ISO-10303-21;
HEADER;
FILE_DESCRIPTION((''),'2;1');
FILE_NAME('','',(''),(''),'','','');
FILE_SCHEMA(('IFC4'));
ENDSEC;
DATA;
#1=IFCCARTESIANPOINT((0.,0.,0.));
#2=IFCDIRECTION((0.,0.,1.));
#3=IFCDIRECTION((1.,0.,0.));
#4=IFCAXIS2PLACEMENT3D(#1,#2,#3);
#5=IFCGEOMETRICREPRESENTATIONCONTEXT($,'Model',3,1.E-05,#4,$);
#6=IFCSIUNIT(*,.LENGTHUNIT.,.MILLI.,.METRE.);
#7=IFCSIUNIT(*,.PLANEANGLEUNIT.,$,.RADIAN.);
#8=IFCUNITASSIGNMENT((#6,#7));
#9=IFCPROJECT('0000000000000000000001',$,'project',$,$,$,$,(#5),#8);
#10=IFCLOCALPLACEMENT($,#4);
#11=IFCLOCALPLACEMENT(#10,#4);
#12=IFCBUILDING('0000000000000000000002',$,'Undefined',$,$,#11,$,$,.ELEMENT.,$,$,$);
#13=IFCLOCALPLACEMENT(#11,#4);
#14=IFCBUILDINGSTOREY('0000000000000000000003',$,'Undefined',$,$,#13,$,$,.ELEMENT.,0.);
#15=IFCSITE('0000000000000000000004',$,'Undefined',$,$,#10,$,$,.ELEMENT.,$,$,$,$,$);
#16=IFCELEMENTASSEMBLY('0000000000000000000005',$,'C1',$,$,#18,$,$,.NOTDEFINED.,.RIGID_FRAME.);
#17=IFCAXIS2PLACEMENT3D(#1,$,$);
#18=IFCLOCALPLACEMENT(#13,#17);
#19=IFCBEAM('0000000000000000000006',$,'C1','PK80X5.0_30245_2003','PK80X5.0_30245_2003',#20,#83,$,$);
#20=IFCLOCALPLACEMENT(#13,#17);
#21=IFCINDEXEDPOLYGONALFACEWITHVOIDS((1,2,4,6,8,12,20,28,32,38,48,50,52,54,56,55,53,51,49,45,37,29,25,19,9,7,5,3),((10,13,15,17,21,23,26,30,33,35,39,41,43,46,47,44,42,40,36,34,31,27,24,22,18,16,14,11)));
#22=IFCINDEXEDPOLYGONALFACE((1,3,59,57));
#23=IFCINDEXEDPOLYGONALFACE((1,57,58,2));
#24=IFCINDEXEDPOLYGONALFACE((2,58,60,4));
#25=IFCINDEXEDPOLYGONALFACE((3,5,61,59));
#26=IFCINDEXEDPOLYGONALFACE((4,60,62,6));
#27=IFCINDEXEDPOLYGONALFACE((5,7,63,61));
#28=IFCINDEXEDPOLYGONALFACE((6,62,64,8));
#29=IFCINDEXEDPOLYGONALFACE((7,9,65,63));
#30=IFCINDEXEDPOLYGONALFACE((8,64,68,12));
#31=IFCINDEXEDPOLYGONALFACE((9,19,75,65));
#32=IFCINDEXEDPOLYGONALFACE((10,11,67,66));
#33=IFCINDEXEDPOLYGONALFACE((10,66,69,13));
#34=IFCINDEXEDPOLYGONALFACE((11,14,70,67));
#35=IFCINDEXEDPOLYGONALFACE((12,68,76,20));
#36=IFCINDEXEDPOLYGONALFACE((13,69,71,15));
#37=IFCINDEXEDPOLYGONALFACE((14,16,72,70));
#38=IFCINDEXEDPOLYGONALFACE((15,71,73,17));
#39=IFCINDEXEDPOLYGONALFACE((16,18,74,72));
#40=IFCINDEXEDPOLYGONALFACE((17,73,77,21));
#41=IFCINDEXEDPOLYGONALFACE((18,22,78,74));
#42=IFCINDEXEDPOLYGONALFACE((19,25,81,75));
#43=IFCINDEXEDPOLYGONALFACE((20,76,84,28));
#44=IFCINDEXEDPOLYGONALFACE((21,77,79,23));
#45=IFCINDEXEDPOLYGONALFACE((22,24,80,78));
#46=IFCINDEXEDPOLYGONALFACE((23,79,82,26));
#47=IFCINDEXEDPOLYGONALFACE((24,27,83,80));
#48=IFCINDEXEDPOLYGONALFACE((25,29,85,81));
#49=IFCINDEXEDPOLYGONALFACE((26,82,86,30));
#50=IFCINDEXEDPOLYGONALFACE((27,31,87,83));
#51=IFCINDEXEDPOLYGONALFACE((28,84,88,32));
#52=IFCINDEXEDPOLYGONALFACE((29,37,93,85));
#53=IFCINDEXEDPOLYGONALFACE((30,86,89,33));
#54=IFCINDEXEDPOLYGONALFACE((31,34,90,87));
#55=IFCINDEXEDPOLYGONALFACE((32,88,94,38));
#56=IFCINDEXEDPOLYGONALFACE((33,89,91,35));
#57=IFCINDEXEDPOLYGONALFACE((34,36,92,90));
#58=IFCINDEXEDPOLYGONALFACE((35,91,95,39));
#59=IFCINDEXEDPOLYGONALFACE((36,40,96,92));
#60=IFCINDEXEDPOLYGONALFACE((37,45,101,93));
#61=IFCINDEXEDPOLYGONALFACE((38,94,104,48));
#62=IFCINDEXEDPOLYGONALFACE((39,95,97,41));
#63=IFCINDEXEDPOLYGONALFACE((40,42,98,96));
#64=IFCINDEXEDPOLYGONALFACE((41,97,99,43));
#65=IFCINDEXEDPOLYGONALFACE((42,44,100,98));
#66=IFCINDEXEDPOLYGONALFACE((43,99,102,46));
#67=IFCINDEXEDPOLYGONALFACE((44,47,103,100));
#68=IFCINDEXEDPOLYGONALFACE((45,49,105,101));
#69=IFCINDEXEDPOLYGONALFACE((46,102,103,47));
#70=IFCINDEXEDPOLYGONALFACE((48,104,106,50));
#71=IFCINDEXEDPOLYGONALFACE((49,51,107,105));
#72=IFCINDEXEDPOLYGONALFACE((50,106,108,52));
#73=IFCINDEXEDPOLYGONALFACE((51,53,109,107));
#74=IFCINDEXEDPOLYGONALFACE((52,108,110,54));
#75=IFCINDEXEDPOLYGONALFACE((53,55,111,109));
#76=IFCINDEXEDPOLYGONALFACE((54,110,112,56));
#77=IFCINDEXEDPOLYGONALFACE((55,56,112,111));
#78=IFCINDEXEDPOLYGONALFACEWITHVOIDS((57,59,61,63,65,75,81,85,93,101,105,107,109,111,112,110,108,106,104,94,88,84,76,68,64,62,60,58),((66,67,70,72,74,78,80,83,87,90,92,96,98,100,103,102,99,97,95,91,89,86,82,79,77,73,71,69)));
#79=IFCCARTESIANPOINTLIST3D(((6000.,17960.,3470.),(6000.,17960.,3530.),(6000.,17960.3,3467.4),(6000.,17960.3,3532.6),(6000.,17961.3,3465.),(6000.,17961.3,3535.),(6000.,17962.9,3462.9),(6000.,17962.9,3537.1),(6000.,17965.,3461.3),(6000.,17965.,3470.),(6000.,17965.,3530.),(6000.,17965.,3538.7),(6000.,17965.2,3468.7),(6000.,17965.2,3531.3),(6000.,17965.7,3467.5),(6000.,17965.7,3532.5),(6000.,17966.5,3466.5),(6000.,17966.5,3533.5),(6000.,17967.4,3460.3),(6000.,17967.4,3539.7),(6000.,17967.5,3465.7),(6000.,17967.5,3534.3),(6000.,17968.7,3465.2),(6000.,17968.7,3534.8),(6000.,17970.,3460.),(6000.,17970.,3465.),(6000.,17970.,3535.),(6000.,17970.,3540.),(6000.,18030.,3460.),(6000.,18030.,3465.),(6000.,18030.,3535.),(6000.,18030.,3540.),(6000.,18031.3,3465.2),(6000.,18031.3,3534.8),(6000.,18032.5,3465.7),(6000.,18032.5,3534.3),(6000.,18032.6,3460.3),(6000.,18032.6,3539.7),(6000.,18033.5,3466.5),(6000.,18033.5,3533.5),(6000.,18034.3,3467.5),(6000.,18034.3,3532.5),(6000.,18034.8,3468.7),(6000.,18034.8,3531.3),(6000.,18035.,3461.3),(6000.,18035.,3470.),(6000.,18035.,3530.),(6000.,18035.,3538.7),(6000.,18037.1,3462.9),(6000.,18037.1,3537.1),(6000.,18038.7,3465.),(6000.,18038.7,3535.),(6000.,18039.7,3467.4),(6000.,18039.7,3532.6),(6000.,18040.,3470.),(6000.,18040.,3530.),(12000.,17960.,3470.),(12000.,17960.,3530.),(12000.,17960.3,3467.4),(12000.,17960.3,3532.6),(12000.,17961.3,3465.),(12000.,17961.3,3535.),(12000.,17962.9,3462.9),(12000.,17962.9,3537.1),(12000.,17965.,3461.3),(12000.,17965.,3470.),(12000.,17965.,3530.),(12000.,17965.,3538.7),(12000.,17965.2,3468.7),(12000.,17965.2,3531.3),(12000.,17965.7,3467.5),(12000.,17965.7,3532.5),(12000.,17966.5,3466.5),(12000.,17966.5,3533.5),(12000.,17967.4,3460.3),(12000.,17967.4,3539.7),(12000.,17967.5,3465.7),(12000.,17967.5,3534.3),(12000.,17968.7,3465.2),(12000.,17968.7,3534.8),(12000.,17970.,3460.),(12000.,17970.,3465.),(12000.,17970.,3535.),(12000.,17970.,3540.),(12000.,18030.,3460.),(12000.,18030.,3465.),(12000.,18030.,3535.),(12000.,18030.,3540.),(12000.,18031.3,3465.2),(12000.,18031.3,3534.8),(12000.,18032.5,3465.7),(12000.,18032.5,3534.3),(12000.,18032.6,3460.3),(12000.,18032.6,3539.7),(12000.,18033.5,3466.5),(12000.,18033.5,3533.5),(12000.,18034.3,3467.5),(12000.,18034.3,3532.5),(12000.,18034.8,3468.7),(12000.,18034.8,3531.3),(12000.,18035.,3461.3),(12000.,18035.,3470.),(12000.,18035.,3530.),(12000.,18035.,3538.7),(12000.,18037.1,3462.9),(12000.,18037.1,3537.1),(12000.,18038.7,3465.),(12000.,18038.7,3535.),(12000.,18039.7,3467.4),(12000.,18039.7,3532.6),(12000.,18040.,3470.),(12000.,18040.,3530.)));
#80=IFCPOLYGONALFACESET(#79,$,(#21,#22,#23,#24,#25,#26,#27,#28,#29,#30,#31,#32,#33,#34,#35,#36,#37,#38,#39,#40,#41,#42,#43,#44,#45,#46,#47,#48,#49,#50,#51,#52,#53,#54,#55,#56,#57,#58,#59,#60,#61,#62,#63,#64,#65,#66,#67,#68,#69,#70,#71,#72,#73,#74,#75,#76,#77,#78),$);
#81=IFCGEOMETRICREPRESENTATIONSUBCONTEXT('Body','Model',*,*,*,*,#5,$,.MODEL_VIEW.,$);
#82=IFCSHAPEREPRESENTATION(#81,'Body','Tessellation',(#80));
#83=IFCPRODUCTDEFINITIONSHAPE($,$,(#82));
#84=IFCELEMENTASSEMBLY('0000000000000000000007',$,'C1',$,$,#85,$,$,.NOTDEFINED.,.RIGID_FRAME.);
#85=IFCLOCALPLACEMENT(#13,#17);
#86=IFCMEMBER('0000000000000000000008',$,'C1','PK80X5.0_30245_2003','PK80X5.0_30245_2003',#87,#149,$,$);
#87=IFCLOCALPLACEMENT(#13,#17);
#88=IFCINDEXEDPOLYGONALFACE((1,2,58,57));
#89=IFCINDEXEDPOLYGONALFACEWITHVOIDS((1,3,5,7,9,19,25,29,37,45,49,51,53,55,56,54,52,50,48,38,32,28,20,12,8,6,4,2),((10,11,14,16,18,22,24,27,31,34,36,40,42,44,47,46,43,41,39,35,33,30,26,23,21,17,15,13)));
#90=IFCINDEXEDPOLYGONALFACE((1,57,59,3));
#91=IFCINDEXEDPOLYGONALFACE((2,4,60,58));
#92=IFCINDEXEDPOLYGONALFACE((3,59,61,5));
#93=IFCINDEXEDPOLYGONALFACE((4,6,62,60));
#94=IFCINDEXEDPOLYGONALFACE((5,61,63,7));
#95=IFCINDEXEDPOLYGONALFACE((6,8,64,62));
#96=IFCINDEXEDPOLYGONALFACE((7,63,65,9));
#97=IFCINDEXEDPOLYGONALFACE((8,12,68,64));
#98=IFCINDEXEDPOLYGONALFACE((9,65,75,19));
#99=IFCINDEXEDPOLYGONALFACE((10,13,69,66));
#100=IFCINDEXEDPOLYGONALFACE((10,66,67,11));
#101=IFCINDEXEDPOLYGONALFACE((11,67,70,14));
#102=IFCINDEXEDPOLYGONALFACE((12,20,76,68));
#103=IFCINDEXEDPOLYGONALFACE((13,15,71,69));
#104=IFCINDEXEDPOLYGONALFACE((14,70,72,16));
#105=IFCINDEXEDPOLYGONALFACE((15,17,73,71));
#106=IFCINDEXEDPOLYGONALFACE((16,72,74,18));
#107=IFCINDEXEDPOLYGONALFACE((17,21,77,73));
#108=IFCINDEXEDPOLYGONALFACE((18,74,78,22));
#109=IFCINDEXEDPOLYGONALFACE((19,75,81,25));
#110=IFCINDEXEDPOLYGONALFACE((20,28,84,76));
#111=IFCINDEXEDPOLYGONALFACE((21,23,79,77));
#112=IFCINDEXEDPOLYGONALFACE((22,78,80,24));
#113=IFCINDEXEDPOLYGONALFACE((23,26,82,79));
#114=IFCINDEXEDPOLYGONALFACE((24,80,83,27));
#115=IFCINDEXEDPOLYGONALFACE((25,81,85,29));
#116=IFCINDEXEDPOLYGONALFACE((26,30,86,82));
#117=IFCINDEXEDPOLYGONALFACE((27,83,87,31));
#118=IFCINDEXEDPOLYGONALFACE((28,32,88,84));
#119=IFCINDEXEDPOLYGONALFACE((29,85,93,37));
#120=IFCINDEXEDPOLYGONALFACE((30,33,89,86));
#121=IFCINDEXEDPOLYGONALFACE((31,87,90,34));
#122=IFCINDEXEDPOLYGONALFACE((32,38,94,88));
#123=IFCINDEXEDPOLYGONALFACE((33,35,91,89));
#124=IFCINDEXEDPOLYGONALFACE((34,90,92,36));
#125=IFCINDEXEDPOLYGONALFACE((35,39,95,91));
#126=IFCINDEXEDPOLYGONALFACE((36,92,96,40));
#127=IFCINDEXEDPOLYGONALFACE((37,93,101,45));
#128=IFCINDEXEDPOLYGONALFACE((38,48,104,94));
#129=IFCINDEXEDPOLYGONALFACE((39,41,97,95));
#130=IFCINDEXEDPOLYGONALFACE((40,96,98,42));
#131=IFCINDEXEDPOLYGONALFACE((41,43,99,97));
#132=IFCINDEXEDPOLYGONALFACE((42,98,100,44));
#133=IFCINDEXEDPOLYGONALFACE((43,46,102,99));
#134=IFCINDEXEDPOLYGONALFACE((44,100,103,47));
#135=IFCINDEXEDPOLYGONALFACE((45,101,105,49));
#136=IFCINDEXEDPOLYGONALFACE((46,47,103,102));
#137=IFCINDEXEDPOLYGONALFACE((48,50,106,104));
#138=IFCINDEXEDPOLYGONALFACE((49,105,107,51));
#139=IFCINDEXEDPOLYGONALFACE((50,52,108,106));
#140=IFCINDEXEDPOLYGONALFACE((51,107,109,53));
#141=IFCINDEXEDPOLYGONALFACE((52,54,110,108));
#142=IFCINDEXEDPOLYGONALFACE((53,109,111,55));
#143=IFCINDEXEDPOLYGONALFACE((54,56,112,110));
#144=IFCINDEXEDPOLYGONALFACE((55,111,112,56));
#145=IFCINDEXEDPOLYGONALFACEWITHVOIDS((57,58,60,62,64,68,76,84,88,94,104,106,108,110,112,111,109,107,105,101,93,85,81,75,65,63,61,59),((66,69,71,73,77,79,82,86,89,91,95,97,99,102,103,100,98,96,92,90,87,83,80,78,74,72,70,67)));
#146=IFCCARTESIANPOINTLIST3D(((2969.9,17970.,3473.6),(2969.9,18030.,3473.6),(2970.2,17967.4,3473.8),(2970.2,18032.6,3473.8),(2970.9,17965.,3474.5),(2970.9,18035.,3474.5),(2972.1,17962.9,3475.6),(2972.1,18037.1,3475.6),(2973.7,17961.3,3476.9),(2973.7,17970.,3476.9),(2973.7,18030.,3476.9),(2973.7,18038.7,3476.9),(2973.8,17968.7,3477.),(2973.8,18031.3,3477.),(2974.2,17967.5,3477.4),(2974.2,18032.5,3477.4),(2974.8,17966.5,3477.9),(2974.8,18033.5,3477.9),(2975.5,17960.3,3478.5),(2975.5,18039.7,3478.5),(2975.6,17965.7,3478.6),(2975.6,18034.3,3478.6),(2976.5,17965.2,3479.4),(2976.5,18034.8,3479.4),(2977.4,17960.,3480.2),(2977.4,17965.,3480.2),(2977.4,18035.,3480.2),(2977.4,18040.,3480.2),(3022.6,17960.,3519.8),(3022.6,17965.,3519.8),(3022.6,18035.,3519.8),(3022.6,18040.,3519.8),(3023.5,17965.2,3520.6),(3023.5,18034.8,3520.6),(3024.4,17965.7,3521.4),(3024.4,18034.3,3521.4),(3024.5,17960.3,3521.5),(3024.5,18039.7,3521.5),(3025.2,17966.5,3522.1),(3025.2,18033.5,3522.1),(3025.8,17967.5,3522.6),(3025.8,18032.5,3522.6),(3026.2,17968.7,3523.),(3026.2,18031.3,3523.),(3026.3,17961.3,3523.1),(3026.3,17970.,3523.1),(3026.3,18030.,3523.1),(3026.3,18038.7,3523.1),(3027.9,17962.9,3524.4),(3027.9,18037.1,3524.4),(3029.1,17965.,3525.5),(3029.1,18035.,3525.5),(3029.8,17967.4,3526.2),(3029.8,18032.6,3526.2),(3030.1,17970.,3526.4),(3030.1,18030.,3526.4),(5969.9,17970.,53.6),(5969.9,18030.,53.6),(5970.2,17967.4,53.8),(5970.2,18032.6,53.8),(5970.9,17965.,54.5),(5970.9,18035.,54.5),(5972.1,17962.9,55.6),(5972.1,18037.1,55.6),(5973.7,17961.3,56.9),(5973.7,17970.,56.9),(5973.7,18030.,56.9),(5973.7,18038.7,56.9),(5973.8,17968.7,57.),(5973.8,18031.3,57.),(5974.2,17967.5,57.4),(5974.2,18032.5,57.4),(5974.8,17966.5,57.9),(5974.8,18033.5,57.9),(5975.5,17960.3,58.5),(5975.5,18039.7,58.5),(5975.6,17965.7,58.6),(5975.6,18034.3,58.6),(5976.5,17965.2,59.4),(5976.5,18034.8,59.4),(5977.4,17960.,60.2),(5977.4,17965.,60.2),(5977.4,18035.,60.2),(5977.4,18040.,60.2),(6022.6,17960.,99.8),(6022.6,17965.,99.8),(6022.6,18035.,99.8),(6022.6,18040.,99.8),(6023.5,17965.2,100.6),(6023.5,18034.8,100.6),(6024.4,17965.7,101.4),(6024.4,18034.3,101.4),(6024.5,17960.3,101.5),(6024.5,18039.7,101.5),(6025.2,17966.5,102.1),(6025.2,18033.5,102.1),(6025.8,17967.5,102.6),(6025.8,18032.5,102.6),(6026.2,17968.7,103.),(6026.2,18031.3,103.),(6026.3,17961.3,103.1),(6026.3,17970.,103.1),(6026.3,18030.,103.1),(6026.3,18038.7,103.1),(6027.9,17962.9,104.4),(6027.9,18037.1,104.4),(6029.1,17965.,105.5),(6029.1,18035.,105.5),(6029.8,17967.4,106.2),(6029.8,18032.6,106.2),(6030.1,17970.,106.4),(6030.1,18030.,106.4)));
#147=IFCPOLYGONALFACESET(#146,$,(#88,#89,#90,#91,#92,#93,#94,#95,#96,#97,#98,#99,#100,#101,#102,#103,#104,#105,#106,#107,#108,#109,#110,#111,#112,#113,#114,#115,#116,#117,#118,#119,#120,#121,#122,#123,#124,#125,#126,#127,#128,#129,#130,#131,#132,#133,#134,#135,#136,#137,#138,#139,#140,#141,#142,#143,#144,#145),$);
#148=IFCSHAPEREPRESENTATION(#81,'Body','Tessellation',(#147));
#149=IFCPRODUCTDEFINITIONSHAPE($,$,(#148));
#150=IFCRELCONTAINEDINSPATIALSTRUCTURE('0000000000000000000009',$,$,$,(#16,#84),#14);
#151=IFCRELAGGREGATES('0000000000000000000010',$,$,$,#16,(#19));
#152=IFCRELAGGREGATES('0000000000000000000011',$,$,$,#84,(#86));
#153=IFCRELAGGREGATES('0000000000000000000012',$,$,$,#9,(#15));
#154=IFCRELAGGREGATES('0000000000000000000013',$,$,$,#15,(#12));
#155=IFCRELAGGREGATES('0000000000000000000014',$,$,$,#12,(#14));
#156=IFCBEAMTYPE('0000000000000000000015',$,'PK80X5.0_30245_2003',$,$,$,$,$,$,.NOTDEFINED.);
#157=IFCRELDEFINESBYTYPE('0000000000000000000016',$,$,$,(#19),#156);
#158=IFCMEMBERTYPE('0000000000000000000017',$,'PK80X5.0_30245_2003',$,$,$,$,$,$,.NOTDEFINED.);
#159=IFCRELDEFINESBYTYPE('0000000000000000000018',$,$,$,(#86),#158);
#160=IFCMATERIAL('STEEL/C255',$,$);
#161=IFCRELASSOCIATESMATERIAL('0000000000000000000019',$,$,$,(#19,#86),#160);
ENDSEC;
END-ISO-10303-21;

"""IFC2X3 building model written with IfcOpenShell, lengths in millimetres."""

from ifc_helpers import new_model, si_unit, frame, origin_with_axes, origin_2d_with_axis, place, context, subcontext, project, spatial, hollow_rectangle, extrude, material, type_object, element, aggregate, save


model = new_model("IFC2X3")

# Units and contexts
model_context = context("Model", 3, precision=1e-05, world=origin_with_axes())
body_context = subcontext(model_context, "Body", "Model", "MODEL_VIEW")
ifc_project = project(units=[si_unit("LENGTHUNIT", "METRE", prefix="MILLI"), si_unit("PLANEANGLEUNIT", "RADIAN")], contexts=[model_context])

# Site, building, storey
site_placement = place(None, origin_with_axes())
site = spatial("IfcSite", under=ifc_project, at=site_placement, Name="Undefined", CompositionType="ELEMENT")
building_placement = place(site_placement, origin_with_axes())
building = spatial("IfcBuilding", under=site, at=building_placement, Name="Undefined", CompositionType="ELEMENT")
storey_placement = place(building_placement, origin_with_axes())
storey = spatial("IfcBuildingStorey", under=building, at=storey_placement, Name="Undefined", CompositionType="ELEMENT", Elevation=0.0)

# Element assembly, beam
ifc_material_1 = material(Name="STEEL/C255")
beam_type_1 = type_object("IfcBeamType", Name="PK80X5.0_30245_2003", PredefinedType="NOTDEFINED")
assembly_1_placement = place(storey_placement, origin_with_axes())
assembly_1 = element("IfcElementAssembly", 1, at=assembly_1_placement, inside=storey, Name="C1", AssemblyPlace="NOTDEFINED", PredefinedType="RIGID_FRAME")
beam_1_placement = place(assembly_1_placement, frame((6000.0, 18000.0, 3500.0), z_axis=(0.0, 0.0, -1.0), x_axis=(1.0, 0.0, 0.0)))
beam_1 = element("IfcBeam", 2, at=beam_1_placement, type_object=beam_type_1, material=ifc_material_1, Name="C1", Description="PK80X5.0_30245_2003", ObjectType="PK80X5.0_30245_2003", context=body_context, shape_type="SweptSolid", body=[
    extrude(hollow_rectangle(XDim=80.0, YDim=80.0, WallThickness=5.0, InnerFilletRadius=5.0, OuterFilletRadius=10.0, at=origin_2d_with_axis()), frame((6000.0, 0.0, 0.0), z_axis=(-1.0, 0.0, 0.0), x_axis=(0.0, -1.0, 0.0)), (0.0, 0.0, 1.0), 6000.0),
])
aggregate(assembly_1, [beam_1])

# Element assembly, member
assembly_2_placement = place(storey_placement, origin_with_axes())
assembly_2 = element("IfcElementAssembly", 3, at=assembly_2_placement, inside=storey, Name="C1", AssemblyPlace="NOTDEFINED", PredefinedType="RIGID_FRAME")
member_type = type_object("IfcMemberType", Name="PK80X5.0_30245_2003", PredefinedType="NOTDEFINED")
member_1_placement = place(assembly_2_placement, frame((6000.0, 18000.0, 80.0), z_axis=(-0.751759, 0.0, -0.659438), x_axis=(-0.659438, 0.0, 0.751759)))
member_1 = element("IfcMember", 4, at=member_1_placement, type_object=member_type, material=ifc_material_1, Name="C1", Description="PK80X5.0_30245_2003", ObjectType="PK80X5.0_30245_2003", context=body_context, shape_type="SweptSolid", body=[
    extrude(hollow_rectangle(XDim=80.0, YDim=80.0, WallThickness=5.0, InnerFilletRadius=5.0, OuterFilletRadius=10.0, at=origin_2d_with_axis()), frame((4549.3, 0.0, 0.0), z_axis=(-1.0, 0.0, 0.0), x_axis=(0.0, -1.0, 0.0)), (0.0, 0.0, 1.0), 4549.3),
])
aggregate(assembly_2, [member_1])

save(model, "model.ifc")
